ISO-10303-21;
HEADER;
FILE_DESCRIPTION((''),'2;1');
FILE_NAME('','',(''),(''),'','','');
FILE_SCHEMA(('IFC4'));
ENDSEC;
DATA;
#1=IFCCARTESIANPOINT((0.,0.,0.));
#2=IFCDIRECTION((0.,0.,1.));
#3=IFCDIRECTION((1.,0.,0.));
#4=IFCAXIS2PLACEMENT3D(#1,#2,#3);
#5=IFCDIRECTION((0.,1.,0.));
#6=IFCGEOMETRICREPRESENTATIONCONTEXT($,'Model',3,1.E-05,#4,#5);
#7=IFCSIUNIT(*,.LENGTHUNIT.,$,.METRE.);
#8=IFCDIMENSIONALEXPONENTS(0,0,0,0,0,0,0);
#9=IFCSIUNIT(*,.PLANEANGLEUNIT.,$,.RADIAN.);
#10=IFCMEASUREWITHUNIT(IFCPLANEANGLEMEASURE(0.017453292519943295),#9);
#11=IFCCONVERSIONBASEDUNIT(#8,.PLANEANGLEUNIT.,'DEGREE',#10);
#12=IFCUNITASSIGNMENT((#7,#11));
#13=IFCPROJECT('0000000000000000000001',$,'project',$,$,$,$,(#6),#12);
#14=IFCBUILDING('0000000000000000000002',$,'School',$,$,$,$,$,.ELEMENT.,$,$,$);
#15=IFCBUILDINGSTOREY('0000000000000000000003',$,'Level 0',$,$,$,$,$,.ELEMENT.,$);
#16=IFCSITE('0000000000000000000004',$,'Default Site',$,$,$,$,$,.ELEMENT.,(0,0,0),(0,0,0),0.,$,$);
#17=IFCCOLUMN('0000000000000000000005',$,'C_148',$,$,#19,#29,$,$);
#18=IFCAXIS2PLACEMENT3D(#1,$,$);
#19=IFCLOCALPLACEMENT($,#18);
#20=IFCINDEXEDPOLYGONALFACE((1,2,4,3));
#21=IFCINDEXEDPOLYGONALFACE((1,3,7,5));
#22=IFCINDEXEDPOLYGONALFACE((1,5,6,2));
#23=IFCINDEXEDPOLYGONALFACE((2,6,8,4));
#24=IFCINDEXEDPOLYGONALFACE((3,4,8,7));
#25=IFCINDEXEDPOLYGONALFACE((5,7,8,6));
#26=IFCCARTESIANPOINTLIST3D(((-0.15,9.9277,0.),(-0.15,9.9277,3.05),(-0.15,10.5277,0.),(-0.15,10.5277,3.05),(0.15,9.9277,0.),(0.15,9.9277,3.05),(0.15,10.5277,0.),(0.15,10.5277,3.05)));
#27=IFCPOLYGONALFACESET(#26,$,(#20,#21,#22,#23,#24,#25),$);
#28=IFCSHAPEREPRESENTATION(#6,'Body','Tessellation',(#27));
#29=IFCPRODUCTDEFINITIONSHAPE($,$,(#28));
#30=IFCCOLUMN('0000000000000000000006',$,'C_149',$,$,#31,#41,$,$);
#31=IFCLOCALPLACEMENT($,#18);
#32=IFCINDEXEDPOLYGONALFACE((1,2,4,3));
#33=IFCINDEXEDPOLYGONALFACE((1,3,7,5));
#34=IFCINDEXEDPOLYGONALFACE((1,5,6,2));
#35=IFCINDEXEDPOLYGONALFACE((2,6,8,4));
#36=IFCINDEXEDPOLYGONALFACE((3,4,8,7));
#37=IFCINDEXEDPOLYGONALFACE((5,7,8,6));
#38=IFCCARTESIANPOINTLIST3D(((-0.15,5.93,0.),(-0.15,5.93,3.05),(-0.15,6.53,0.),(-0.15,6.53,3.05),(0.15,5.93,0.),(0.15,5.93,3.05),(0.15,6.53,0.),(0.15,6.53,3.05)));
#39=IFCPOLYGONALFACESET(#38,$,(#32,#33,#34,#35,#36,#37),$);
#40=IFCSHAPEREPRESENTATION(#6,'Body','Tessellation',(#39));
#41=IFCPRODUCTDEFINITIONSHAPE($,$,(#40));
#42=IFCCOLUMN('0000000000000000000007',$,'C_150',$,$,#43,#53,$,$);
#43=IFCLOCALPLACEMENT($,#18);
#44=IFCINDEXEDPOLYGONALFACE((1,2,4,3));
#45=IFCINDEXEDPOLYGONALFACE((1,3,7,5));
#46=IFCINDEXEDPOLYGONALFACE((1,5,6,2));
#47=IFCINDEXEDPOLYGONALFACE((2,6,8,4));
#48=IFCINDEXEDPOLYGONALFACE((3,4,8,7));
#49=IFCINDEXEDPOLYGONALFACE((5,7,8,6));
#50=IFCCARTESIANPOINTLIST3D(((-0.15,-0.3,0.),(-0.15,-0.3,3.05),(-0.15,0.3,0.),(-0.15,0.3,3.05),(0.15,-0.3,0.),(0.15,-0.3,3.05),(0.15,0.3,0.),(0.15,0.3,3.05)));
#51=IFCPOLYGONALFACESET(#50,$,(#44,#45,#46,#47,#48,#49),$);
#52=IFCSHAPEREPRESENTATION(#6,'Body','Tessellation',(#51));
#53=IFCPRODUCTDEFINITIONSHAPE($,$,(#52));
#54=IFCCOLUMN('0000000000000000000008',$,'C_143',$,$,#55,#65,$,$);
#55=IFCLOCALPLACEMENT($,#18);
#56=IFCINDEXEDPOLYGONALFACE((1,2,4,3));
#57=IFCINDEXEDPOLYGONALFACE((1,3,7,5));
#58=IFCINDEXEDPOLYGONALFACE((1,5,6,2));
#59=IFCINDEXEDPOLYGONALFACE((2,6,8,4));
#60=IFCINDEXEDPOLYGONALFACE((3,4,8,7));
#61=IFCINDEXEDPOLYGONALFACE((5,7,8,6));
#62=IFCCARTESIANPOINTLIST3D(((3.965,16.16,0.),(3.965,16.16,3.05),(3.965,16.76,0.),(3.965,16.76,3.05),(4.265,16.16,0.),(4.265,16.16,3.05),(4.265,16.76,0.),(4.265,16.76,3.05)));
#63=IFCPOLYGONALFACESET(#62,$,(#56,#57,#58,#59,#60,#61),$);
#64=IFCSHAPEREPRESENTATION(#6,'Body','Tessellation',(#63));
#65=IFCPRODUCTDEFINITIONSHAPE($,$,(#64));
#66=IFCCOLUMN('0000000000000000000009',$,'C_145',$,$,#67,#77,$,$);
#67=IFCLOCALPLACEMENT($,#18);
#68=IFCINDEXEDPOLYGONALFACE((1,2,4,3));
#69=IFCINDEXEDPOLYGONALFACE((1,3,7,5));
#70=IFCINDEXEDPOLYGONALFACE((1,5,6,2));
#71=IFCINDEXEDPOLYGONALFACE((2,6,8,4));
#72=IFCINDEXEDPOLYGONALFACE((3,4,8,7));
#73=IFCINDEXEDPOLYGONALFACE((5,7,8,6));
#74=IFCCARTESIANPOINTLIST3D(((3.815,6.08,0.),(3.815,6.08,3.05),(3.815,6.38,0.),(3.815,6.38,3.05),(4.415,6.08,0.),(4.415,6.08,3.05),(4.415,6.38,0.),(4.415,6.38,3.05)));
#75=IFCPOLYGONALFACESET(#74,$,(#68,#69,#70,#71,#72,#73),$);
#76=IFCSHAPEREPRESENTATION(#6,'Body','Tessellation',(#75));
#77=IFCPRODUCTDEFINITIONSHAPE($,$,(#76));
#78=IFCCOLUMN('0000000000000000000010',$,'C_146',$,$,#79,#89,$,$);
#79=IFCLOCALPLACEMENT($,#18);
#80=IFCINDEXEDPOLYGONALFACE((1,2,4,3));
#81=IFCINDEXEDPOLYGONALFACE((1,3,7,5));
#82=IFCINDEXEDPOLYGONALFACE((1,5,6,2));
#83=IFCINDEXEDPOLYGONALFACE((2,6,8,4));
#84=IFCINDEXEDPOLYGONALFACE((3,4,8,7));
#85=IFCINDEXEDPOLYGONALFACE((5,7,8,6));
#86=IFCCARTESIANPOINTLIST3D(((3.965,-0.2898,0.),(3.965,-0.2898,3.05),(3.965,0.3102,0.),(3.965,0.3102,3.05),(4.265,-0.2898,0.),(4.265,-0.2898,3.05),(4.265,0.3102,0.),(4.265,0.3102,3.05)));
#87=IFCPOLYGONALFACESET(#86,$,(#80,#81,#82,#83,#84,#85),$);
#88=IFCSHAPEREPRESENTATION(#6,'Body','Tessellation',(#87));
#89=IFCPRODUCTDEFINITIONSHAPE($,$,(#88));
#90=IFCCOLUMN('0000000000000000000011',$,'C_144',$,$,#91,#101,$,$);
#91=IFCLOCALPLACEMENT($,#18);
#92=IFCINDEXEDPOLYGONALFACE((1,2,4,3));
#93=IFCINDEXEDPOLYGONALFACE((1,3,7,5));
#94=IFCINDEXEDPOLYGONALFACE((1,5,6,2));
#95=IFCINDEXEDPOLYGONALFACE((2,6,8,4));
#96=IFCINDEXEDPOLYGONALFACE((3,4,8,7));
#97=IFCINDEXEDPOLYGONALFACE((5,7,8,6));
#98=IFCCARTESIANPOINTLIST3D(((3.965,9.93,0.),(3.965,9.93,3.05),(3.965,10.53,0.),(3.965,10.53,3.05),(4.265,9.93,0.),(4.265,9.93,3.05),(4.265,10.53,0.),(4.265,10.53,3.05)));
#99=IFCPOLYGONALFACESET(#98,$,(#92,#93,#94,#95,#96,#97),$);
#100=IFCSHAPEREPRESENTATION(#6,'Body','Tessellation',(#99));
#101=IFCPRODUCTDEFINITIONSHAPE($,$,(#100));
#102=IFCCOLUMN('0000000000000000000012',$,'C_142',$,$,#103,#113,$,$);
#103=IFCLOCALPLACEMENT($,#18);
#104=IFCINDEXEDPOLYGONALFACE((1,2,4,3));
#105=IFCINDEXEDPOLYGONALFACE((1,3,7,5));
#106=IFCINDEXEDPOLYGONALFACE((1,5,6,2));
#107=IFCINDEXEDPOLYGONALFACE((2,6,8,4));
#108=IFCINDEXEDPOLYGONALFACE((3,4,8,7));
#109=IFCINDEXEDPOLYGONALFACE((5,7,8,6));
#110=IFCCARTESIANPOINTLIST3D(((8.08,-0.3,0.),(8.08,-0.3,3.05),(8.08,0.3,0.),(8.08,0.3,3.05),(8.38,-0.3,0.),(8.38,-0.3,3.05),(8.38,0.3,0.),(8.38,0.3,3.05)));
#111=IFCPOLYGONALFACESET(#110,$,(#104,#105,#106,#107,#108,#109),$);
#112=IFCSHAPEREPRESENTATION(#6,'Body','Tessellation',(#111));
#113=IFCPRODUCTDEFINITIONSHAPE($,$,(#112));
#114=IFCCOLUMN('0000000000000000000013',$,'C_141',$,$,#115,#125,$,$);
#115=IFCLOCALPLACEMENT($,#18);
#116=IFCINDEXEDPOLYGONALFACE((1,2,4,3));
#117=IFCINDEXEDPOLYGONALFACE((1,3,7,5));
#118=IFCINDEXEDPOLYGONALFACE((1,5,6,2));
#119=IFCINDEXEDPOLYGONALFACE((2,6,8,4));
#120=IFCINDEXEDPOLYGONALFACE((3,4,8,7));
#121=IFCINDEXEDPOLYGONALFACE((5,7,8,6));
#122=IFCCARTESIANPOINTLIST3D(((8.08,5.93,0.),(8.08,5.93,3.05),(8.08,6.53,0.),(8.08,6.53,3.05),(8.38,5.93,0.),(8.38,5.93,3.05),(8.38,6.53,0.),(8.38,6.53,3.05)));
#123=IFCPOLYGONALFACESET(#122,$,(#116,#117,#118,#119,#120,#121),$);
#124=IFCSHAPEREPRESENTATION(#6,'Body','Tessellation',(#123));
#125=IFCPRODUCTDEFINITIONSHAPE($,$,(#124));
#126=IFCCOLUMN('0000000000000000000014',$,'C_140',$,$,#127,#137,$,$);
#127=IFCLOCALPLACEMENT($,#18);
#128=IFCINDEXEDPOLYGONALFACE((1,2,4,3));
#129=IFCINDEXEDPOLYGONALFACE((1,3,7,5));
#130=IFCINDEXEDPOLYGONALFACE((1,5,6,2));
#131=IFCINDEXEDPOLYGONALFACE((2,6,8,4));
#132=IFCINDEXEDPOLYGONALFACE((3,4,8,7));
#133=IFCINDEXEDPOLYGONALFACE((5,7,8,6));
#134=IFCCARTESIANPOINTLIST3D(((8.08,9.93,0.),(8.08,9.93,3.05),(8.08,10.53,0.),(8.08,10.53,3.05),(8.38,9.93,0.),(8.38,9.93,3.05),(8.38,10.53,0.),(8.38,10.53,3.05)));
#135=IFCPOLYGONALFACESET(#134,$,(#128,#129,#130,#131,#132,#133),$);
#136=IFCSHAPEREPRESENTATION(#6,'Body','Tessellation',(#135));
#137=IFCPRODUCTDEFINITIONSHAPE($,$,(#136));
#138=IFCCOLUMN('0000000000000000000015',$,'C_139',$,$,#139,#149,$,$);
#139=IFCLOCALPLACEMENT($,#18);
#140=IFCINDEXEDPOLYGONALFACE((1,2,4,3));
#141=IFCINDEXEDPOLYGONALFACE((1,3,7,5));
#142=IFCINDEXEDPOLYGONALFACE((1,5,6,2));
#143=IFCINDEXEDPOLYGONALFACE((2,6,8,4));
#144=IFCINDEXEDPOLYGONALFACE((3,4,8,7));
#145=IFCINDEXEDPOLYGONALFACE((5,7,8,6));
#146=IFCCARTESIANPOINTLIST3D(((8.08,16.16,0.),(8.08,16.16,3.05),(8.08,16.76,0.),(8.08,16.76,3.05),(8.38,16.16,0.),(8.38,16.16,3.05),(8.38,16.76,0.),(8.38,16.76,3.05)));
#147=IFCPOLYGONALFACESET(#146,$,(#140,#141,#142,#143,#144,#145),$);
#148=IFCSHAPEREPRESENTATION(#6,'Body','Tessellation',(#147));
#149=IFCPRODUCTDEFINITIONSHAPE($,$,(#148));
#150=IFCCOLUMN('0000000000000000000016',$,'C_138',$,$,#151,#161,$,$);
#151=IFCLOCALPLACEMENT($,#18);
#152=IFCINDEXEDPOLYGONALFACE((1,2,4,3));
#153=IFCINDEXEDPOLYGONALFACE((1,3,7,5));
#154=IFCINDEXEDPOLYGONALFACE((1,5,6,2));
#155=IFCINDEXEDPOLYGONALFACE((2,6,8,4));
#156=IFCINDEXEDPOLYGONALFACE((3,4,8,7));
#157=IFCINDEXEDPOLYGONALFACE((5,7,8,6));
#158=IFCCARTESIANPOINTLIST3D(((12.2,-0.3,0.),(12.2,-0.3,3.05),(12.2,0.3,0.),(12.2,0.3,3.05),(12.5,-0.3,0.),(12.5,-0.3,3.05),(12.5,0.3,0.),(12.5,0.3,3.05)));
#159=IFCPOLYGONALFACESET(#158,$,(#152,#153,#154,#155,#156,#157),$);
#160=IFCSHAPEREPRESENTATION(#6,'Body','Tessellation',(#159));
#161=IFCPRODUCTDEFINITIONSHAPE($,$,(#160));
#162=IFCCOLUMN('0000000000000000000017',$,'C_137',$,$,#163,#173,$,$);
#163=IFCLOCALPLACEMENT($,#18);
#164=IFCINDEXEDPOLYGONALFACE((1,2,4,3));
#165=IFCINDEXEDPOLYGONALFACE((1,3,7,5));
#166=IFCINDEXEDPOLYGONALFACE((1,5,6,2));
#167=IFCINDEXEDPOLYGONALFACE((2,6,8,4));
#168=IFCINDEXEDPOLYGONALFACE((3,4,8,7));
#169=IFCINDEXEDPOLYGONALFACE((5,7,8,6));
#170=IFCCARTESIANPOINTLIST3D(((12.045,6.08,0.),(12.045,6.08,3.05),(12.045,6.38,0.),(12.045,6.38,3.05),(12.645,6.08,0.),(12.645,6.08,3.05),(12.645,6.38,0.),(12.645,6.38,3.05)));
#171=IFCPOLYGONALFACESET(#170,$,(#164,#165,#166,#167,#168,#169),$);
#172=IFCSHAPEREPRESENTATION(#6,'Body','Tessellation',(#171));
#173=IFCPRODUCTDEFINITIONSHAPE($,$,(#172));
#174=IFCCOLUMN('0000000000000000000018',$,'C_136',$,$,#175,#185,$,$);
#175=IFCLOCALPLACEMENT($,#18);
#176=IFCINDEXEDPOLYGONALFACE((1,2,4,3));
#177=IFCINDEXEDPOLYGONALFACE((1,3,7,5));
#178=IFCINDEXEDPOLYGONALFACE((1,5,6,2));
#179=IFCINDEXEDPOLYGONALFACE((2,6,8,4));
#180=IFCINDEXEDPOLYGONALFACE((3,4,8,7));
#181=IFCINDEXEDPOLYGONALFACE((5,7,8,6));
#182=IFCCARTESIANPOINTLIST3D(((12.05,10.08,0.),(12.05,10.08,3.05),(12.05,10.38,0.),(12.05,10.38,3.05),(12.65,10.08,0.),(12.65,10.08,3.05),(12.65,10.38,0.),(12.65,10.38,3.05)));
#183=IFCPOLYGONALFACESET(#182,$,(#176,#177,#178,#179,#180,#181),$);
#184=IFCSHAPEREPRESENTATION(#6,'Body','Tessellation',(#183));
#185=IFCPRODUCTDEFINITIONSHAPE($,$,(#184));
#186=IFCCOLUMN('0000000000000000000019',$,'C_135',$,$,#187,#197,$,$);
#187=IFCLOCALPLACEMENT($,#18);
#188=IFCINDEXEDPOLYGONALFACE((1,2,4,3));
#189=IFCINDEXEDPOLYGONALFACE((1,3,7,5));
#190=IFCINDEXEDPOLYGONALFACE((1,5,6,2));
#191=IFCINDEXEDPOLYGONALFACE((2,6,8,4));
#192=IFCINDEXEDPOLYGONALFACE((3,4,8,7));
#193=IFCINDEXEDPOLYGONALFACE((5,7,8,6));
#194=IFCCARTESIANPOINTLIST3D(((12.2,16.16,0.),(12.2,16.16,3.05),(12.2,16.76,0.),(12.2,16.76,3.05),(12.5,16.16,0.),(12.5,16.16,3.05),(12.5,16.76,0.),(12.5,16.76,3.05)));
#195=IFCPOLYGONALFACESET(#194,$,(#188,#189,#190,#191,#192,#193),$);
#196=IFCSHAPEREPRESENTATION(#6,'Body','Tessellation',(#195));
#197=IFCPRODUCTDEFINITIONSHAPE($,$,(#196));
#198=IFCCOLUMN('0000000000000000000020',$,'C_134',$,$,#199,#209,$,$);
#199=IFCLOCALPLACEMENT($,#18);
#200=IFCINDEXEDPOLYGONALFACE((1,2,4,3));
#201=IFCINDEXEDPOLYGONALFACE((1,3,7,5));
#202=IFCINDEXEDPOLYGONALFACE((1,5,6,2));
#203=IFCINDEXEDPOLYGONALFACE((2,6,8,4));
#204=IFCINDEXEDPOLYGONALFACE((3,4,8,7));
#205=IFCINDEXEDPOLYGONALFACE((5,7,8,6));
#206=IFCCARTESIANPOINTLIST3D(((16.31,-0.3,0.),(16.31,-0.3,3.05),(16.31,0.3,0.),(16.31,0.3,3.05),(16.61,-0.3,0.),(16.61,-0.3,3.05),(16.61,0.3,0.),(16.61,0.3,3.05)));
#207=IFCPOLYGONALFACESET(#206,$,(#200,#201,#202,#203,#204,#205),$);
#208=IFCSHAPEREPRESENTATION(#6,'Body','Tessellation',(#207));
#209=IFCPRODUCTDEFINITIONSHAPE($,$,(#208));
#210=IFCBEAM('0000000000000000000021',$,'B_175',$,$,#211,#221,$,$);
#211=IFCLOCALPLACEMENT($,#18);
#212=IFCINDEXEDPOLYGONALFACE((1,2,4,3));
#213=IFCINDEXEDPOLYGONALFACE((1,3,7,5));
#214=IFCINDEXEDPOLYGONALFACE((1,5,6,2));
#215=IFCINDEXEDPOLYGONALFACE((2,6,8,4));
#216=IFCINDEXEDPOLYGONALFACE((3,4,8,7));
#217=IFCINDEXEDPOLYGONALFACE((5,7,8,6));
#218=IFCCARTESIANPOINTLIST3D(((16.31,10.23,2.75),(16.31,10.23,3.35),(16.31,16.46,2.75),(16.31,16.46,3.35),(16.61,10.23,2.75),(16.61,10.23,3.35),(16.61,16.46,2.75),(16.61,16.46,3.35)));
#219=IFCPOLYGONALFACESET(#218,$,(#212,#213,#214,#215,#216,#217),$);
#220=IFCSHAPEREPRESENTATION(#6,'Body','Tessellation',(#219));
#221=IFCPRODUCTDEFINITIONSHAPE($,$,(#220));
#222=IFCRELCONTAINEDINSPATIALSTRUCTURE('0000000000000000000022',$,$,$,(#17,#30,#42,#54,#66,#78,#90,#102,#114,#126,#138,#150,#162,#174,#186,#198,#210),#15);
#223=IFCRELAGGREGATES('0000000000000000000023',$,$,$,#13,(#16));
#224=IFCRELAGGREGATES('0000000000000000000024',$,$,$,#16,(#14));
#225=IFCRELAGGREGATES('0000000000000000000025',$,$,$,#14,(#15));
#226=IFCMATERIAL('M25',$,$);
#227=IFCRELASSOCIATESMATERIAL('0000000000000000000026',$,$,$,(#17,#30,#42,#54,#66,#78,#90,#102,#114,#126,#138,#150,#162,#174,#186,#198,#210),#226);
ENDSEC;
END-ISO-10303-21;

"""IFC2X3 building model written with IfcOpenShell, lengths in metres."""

from ifc_helpers import new_model, entity, si_unit, converted_unit, direction, frame, frame_2d, origin_with_axes, place, context, project, spatial, rectangle, extrude, material, element, save


model = new_model("IFC2X3")

# Units and contexts
model_context = context("Model", 3, precision=1e-05, world=origin_with_axes(), true_north=direction((0.0, 1.0, 0.0)))
ifc_project = project(units=[si_unit("LENGTHUNIT", "METRE"), converted_unit("PLANEANGLEUNIT", "DEGREE", entity("IfcPlaneAngleMeasure", 0.017453292519943295), si_unit("PLANEANGLEUNIT", "RADIAN"), dimensions=[0, 0, 0, 0, 0, 0, 0])], contexts=[model_context])

# Site, building, storey
site = spatial("IfcSite", under=ifc_project, Name="Default Site", CompositionType="ELEMENT", RefLatitude=(0, 0, 0), RefLongitude=(0, 0, 0), RefElevation=0.0)
building = spatial("IfcBuilding", under=site, Name="School", CompositionType="ELEMENT")
storey = spatial("IfcBuildingStorey", under=building, Name="Level 0", CompositionType="ELEMENT")

# Columns
ifc_material = material(Name="M25")
placement = place(None, origin_with_axes())
element("IfcColumn", 1, at=placement, inside=storey, material=ifc_material, Name="C_148", context=model_context, shape_type="SweptSolid", body=[
    extrude(rectangle(XDim=0.3, YDim=0.6, at=frame_2d((0.0, 0.0), x_axis=(1.0, 0.0, 0.0))), frame((0.0, 10.2277, 0.0), z_axis=(0.0, 0.0, 1.0), x_axis=(1.0, 0.0, 0.0)), (0.0, 0.0, 1.0), 3.05),
])
element("IfcColumn", 2, at=placement, inside=storey, material=ifc_material, Name="C_149", context=model_context, shape_type="SweptSolid", body=[
    extrude(rectangle(XDim=0.3, YDim=0.6, at=frame_2d((0.0, 0.0), x_axis=(1.0, 0.0, 0.0))), frame((0.0, 6.23, 0.0), z_axis=(0.0, 0.0, 1.0), x_axis=(1.0, 0.0, 0.0)), (0.0, 0.0, 1.0), 3.05),
])
element("IfcColumn", 3, at=placement, inside=storey, material=ifc_material, Name="C_150", context=model_context, shape_type="SweptSolid", body=[
    extrude(rectangle(XDim=0.3, YDim=0.6, at=frame_2d((0.0, 0.0), x_axis=(1.0, 0.0, 0.0))), frame((0.0, 0.0, 0.0), z_axis=(0.0, 0.0, 1.0), x_axis=(1.0, 0.0, 0.0)), (0.0, 0.0, 1.0), 3.05),
])
element("IfcColumn", 4, at=placement, inside=storey, material=ifc_material, Name="C_143", context=model_context, shape_type="SweptSolid", body=[
    extrude(rectangle(XDim=0.3, YDim=0.6, at=frame_2d((0.0, 0.0), x_axis=(1.0, 0.0, 0.0))), frame((4.115, 16.46, 0.0), z_axis=(0.0, 0.0, 1.0), x_axis=(1.0, 0.0, 0.0)), (0.0, 0.0, 1.0), 3.05),
])
element("IfcColumn", 5, at=placement, inside=storey, material=ifc_material, Name="C_145", context=model_context, shape_type="SweptSolid", body=[
    extrude(rectangle(XDim=0.6, YDim=0.3, at=frame_2d((0.0, 0.0), x_axis=(1.0, 0.0, 0.0))), frame((4.115, 6.23, 0.0), z_axis=(0.0, 0.0, 1.0), x_axis=(1.0, 0.0, 0.0)), (0.0, 0.0, 1.0), 3.05),
])
element("IfcColumn", 6, at=placement, inside=storey, material=ifc_material, Name="C_146", context=model_context, shape_type="SweptSolid", body=[
    extrude(rectangle(XDim=0.3, YDim=0.6, at=frame_2d((0.0, 0.0), x_axis=(1.0, 0.0, 0.0))), frame((4.115, 0.0102, 0.0), z_axis=(0.0, 0.0, 1.0), x_axis=(1.0, 0.0, 0.0)), (0.0, 0.0, 1.0), 3.05),
])
element("IfcColumn", 7, at=placement, inside=storey, material=ifc_material, Name="C_144", context=model_context, shape_type="SweptSolid", body=[
    extrude(rectangle(XDim=0.3, YDim=0.6, at=frame_2d((0.0, 0.0), x_axis=(1.0, 0.0, 0.0))), frame((4.115, 10.23, 0.0), z_axis=(0.0, 0.0, 1.0), x_axis=(1.0, 0.0, 0.0)), (0.0, 0.0, 1.0), 3.05),
])
element("IfcColumn", 8, at=placement, inside=storey, material=ifc_material, Name="C_142", context=model_context, shape_type="SweptSolid", body=[
    extrude(rectangle(XDim=0.3, YDim=0.6, at=frame_2d((0.0, 0.0), x_axis=(1.0, 0.0, 0.0))), frame((8.23, 0.0, 0.0), z_axis=(0.0, 0.0, 1.0), x_axis=(1.0, 0.0, 0.0)), (0.0, 0.0, 1.0), 3.05),
])
element("IfcColumn", 9, at=placement, inside=storey, material=ifc_material, Name="C_141", context=model_context, shape_type="SweptSolid", body=[
    extrude(rectangle(XDim=0.3, YDim=0.6, at=frame_2d((0.0, 0.0), x_axis=(1.0, 0.0, 0.0))), frame((8.23, 6.23, 0.0), z_axis=(0.0, 0.0, 1.0), x_axis=(1.0, 0.0, 0.0)), (0.0, 0.0, 1.0), 3.05),
])
element("IfcColumn", 10, at=placement, inside=storey, material=ifc_material, Name="C_140", context=model_context, shape_type="SweptSolid", body=[
    extrude(rectangle(XDim=0.3, YDim=0.6, at=frame_2d((0.0, 0.0), x_axis=(1.0, 0.0, 0.0))), frame((8.23, 10.23, 0.0), z_axis=(0.0, 0.0, 1.0), x_axis=(1.0, 0.0, 0.0)), (0.0, 0.0, 1.0), 3.05),
])
element("IfcColumn", 11, at=placement, inside=storey, material=ifc_material, Name="C_139", context=model_context, shape_type="SweptSolid", body=[
    extrude(rectangle(XDim=0.3, YDim=0.6, at=frame_2d((0.0, 0.0), x_axis=(1.0, 0.0, 0.0))), frame((8.23, 16.46, 0.0), z_axis=(0.0, 0.0, 1.0), x_axis=(1.0, 0.0, 0.0)), (0.0, 0.0, 1.0), 3.05),
])
element("IfcColumn", 12, at=placement, inside=storey, material=ifc_material, Name="C_138", context=model_context, shape_type="SweptSolid", body=[
    extrude(rectangle(XDim=0.3, YDim=0.6, at=frame_2d((0.0, 0.0), x_axis=(1.0, 0.0, 0.0))), frame((12.35, 0.0, 0.0), z_axis=(0.0, 0.0, 1.0), x_axis=(1.0, 0.0, 0.0)), (0.0, 0.0, 1.0), 3.05),
])
element("IfcColumn", 13, at=placement, inside=storey, material=ifc_material, Name="C_137", context=model_context, shape_type="SweptSolid", body=[
    extrude(rectangle(XDim=0.6, YDim=0.3, at=frame_2d((0.0, 0.0), x_axis=(1.0, 0.0, 0.0))), frame((12.345, 6.23, 0.0), z_axis=(0.0, 0.0, 1.0), x_axis=(1.0, 0.0, 0.0)), (0.0, 0.0, 1.0), 3.05),
])
element("IfcColumn", 14, at=placement, inside=storey, material=ifc_material, Name="C_136", context=model_context, shape_type="SweptSolid", body=[
    extrude(rectangle(XDim=0.6, YDim=0.3, at=frame_2d((0.0, 0.0), x_axis=(1.0, 0.0, 0.0))), frame((12.35, 10.23, 0.0), z_axis=(0.0, 0.0, 1.0), x_axis=(1.0, 0.0, 0.0)), (0.0, 0.0, 1.0), 3.05),
])
element("IfcColumn", 15, at=placement, inside=storey, material=ifc_material, Name="C_135", context=model_context, shape_type="SweptSolid", body=[
    extrude(rectangle(XDim=0.3, YDim=0.6, at=frame_2d((0.0, 0.0), x_axis=(1.0, 0.0, 0.0))), frame((12.35, 16.46, 0.0), z_axis=(0.0, 0.0, 1.0), x_axis=(1.0, 0.0, 0.0)), (0.0, 0.0, 1.0), 3.05),
])
element("IfcColumn", 16, at=placement, inside=storey, material=ifc_material, Name="C_134", context=model_context, shape_type="SweptSolid", body=[
    extrude(rectangle(XDim=0.3, YDim=0.6, at=frame_2d((0.0, 0.0), x_axis=(1.0, 0.0, 0.0))), frame((16.46, 0.0, 0.0), z_axis=(0.0, 0.0, 1.0), x_axis=(1.0, 0.0, 0.0)), (0.0, 0.0, 1.0), 3.05),
])

# Beam
element("IfcBeam", 17, at=placement, inside=storey, material=ifc_material, Name="B_175", context=model_context, shape_type="SweptSolid", body=[
    extrude(rectangle(XDim=0.3, YDim=0.6, at=frame_2d((0.0, 0.0), x_axis=(0.0, 1.0, 0.0))), frame((16.46, 10.23, 3.05), z_axis=(0.0, 1.0, 0.0), x_axis=(0.0, 0.0, -1.0)), (0.0, 0.0, 1.0), 6.23),
])

save(model, "model.ifc")
